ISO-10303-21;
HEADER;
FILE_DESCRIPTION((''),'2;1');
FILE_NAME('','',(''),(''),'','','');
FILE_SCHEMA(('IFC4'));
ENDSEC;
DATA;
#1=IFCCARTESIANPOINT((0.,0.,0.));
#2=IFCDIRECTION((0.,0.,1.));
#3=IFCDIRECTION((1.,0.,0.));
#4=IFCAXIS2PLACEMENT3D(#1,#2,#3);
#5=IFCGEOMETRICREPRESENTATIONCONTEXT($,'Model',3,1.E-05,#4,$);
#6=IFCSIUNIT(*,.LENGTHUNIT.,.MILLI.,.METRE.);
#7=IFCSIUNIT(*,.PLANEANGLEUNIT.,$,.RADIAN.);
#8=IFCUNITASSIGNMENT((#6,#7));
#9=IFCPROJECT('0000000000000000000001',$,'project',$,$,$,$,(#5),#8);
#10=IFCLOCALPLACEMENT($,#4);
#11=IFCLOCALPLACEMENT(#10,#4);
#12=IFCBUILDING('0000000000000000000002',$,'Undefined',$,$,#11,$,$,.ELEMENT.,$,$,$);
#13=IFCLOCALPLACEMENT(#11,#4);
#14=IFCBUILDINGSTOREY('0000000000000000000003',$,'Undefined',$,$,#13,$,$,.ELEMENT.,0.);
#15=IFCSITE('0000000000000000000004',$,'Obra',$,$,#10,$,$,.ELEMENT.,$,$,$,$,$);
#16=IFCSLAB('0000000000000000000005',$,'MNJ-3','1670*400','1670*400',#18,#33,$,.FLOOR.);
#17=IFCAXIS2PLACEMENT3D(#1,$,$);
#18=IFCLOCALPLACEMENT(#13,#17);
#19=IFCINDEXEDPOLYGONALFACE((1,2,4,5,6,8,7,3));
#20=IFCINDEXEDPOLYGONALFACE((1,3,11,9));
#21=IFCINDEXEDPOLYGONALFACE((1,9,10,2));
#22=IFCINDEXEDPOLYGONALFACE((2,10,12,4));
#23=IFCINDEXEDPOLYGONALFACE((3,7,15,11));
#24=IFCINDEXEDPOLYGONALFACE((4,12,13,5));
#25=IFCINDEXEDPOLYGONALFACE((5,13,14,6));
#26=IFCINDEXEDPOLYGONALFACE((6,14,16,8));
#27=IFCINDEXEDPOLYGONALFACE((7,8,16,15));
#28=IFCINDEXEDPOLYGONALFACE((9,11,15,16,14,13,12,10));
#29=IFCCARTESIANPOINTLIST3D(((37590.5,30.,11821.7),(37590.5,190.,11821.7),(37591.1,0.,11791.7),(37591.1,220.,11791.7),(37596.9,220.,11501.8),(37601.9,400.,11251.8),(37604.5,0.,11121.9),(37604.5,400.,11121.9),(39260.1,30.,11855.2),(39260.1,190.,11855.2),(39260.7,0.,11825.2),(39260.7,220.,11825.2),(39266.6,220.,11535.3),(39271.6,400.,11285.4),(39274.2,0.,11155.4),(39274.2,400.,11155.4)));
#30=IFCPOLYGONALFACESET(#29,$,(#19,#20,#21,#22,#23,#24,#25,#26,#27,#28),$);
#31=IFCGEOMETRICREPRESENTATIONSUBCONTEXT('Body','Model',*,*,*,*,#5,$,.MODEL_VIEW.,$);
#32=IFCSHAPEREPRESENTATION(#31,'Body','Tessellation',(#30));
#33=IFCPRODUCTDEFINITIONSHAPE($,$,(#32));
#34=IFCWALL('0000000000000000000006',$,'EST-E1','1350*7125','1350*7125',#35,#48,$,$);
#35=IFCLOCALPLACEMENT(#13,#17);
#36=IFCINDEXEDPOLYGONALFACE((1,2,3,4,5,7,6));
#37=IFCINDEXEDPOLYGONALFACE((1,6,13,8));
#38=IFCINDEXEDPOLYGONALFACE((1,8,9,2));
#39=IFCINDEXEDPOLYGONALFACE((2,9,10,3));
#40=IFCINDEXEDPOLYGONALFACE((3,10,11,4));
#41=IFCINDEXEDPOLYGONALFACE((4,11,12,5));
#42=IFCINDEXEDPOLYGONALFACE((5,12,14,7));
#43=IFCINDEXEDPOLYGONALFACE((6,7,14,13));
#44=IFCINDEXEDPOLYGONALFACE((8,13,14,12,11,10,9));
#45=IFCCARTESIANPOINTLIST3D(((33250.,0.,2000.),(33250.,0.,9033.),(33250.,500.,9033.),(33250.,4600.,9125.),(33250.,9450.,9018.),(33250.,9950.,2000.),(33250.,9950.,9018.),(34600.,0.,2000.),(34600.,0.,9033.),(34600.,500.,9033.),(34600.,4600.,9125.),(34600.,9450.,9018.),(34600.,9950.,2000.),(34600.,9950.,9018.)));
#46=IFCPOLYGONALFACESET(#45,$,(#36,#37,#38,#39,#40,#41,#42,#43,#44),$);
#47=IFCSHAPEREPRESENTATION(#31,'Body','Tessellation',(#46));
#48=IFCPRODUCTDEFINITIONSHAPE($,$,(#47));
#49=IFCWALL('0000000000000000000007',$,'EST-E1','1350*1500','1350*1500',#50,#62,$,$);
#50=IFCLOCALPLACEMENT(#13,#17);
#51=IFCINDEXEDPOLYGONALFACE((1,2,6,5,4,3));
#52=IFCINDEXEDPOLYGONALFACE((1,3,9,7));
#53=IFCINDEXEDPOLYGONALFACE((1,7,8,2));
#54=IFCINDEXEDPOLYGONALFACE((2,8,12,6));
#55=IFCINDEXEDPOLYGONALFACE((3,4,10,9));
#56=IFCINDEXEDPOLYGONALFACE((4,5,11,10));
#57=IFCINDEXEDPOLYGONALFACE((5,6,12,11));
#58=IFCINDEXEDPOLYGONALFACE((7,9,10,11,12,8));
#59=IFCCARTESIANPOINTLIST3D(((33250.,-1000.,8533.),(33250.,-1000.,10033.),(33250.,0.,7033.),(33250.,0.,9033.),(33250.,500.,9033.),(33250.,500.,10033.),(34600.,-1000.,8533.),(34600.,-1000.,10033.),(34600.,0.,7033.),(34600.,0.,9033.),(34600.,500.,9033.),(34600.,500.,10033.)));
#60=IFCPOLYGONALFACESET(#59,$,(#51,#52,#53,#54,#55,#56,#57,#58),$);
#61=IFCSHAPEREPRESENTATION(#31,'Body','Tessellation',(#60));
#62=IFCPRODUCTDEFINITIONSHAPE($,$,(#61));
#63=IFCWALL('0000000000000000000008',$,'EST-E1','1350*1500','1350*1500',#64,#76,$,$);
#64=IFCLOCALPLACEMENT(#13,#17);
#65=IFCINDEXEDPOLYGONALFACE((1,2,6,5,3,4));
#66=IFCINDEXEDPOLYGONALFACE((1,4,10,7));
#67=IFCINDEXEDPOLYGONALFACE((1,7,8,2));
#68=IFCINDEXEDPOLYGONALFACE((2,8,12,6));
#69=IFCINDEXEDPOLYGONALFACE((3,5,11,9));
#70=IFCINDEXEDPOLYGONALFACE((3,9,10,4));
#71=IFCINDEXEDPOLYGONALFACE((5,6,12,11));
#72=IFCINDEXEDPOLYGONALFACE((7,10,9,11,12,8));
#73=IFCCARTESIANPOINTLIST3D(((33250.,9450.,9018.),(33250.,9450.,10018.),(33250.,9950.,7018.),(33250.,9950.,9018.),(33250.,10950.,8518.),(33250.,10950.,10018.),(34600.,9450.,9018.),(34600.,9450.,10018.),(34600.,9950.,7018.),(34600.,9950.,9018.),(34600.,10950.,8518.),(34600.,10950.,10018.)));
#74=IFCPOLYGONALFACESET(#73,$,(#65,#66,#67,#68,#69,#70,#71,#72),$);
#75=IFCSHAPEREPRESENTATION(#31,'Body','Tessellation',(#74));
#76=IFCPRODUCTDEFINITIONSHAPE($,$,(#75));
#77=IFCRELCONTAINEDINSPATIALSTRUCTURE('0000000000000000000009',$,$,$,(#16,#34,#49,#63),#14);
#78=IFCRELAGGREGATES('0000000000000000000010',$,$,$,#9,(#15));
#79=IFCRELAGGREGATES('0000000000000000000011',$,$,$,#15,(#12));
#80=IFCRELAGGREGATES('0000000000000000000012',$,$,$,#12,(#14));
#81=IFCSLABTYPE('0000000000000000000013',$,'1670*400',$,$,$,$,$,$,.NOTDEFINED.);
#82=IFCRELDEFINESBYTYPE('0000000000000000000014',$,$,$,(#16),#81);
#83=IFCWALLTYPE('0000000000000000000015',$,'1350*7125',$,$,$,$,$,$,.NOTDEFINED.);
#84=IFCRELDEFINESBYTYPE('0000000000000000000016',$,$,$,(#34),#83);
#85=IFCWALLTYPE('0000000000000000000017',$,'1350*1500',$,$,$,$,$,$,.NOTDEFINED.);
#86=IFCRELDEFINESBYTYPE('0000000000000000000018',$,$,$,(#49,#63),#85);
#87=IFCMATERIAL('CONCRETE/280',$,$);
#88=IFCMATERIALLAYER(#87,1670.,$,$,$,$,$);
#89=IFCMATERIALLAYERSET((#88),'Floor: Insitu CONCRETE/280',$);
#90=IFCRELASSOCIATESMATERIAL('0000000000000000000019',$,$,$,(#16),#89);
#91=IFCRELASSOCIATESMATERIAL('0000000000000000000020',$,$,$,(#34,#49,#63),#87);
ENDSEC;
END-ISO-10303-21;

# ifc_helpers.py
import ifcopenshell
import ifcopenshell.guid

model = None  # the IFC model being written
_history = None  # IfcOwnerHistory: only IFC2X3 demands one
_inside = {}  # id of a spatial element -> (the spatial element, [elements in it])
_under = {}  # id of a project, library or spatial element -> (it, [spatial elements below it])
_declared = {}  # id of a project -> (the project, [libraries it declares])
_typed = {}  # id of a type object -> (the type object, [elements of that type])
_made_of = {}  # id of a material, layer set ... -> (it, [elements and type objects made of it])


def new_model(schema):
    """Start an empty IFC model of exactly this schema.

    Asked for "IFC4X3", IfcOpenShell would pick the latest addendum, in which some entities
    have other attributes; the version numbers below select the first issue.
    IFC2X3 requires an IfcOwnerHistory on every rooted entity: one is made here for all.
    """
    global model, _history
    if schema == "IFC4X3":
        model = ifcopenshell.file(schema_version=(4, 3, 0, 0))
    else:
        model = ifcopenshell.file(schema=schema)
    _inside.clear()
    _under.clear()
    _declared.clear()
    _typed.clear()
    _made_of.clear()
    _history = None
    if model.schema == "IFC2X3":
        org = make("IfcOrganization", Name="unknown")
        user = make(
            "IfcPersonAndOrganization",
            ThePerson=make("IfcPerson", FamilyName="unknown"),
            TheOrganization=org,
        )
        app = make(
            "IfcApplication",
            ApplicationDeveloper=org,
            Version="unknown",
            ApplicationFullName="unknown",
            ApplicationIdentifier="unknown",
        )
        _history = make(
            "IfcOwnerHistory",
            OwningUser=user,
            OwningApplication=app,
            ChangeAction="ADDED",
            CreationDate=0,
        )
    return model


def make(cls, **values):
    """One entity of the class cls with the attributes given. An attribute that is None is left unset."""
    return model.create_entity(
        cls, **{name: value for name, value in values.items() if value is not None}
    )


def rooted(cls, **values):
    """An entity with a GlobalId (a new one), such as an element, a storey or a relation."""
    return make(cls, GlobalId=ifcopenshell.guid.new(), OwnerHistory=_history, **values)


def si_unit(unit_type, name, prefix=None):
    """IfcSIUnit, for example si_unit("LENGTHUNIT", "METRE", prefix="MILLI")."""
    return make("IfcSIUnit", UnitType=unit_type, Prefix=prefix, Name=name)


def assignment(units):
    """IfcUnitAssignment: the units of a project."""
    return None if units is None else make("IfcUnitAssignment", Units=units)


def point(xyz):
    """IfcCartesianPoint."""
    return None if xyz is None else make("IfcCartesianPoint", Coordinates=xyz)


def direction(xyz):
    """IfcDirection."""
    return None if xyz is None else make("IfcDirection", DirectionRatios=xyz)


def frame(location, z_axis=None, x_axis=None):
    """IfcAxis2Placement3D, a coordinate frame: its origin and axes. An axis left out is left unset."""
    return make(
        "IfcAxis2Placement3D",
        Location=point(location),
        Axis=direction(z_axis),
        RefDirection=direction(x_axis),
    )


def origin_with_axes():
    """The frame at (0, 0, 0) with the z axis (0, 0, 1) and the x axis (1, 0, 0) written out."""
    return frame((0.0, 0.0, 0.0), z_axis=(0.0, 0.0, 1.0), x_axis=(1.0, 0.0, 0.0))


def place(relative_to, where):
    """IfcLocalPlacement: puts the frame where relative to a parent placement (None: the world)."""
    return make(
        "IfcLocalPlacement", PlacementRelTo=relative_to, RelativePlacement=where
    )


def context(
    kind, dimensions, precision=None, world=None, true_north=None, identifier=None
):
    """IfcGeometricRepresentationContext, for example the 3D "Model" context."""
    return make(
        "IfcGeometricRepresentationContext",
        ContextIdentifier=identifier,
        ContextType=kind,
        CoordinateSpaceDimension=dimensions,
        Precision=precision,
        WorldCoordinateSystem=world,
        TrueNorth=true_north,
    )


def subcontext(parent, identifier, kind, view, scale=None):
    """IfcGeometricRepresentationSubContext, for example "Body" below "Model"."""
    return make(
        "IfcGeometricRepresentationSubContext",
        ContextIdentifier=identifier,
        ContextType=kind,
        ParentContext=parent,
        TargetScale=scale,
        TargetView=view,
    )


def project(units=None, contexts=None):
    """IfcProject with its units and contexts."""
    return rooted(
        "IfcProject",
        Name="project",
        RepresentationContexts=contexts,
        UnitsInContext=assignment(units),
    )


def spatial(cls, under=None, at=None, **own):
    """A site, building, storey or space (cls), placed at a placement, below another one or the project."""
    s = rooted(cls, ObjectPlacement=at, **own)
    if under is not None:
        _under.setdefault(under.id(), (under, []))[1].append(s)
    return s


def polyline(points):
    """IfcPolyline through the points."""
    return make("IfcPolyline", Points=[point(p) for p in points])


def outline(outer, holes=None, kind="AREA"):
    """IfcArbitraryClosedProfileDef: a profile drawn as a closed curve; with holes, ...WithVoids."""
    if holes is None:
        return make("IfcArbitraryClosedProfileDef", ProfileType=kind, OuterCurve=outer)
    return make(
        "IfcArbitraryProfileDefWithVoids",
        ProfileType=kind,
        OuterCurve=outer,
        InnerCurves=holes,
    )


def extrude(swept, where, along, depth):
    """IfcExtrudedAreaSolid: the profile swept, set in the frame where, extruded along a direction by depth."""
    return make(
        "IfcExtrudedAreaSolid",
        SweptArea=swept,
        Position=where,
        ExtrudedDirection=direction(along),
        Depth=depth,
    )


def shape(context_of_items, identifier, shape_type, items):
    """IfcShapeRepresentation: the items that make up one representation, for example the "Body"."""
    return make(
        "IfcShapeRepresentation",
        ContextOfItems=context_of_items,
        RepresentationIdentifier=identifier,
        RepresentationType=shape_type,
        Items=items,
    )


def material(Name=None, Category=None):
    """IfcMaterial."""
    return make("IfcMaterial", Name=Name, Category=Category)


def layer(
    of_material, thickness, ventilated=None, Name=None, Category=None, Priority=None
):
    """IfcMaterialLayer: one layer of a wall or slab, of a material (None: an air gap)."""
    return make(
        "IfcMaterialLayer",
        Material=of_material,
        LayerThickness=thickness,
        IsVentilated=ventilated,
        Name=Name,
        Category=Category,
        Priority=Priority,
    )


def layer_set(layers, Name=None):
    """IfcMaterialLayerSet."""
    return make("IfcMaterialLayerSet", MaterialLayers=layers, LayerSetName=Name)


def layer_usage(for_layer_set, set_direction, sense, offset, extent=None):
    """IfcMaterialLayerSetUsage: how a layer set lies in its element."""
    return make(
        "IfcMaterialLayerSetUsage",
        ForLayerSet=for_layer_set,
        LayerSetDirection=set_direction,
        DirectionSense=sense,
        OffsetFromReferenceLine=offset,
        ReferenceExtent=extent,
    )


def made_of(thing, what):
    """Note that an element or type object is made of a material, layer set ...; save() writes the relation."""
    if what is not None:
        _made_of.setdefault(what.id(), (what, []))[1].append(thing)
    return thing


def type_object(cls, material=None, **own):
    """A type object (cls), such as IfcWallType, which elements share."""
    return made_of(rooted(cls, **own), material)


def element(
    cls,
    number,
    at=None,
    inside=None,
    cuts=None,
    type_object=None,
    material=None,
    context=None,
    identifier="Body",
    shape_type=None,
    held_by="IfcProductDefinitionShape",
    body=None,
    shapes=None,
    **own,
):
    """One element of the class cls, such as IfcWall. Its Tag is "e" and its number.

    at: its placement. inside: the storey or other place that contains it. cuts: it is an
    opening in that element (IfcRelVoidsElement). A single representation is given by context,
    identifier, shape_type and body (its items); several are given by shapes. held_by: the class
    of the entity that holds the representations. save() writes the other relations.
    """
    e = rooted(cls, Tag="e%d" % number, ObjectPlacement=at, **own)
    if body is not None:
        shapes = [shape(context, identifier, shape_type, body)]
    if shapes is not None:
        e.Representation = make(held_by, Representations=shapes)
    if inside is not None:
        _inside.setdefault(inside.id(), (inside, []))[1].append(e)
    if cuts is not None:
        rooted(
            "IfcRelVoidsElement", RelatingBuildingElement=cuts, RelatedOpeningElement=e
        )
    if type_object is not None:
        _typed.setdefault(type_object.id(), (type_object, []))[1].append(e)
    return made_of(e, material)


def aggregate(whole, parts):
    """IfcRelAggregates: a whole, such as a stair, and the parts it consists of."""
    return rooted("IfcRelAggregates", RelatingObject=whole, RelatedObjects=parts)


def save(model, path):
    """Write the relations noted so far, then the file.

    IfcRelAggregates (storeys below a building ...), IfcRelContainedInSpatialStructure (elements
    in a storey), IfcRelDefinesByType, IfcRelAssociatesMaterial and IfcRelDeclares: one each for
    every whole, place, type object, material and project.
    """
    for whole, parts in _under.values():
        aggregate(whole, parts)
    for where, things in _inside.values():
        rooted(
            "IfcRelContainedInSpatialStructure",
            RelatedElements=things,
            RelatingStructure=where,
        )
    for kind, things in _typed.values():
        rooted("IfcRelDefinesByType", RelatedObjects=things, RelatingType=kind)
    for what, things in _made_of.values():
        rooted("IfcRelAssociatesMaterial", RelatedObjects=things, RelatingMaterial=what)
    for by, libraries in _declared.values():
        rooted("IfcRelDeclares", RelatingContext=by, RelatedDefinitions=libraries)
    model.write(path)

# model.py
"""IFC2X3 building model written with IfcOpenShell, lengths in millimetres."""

from ifc_helpers import new_model, si_unit, frame, origin_with_axes, place, context, subcontext, project, spatial, polyline, outline, extrude, material, layer, layer_set, layer_usage, type_object, element, save


model = new_model("IFC2X3")

# Units and contexts
model_context = context("Model", 3, precision=1e-05, world=origin_with_axes())
body_context = subcontext(model_context, "Body", "Model", "MODEL_VIEW")
ifc_project = project(units=[si_unit("LENGTHUNIT", "METRE", prefix="MILLI"), si_unit("PLANEANGLEUNIT", "RADIAN")], contexts=[model_context])

# Site, building, storey
site_placement = place(None, origin_with_axes())
site = spatial("IfcSite", under=ifc_project, at=site_placement, Name="Obra", CompositionType="ELEMENT")
building_placement = place(site_placement, origin_with_axes())
building = spatial("IfcBuilding", under=site, at=building_placement, Name="Undefined", CompositionType="ELEMENT")
storey_placement = place(building_placement, origin_with_axes())
storey = spatial("IfcBuildingStorey", under=building, at=storey_placement, Name="Undefined", CompositionType="ELEMENT", Elevation=0.0)

# Shared definitions
ifc_material_1 = material(Name="CONCRETE/280")

# Slab
ifc_layer_1 = layer(ifc_material_1, 1670.0)
ifc_layer_set_1 = layer_set([ifc_layer_1], Name="Floor: Insitu CONCRETE/280")
slab_type_1 = type_object("IfcSlabType", Name="1670*400", PredefinedType="NOTDEFINED")
ifc_layer_usage_1 = layer_usage(ifc_layer_set_1, "AXIS3", "POSITIVE", -835.0)
slab_1_placement = place(storey_placement, frame((38425.9, 0.0, 11808.5), z_axis=(0.999799, 0.0, 0.02007), x_axis=(0.02007, 0.0, -0.999799)))
element("IfcSlab", 1, at=slab_1_placement, inside=storey, type_object=slab_type_1, material=ifc_layer_usage_1, Name="MNJ-3", Description="1670*400", ObjectType="1670*400", PredefinedType="FLOOR", context=body_context, shape_type="SweptSolid", body=[
    extrude(outline(polyline([(0.0, 0.0), (670.0, 0.0), (670.0, 400.0), (540.0, 400.0), (290.0, 220.0), (0.0, 220.0), (-30.0, 190.0), (-30.0, 30.0), (0.0, 0.0)])), frame((0.0, 0.0, -835.0), z_axis=(0.0, 0.0, 1.0), x_axis=(1.0, 0.0, 0.0)), (0.0, 0.0, 1.0), 1670.0),
])

# Walls
wall_type_1 = type_object("IfcWallType", Name="1350*7125", PredefinedType="NOTDEFINED")
wall_placement = place(storey_placement, frame((33925.0, 9450.0, 9018.0), z_axis=(-1.0, 0.0, 0.0), x_axis=(0.0, 1.0, 0.0)))
element("IfcWall", 2, at=wall_placement, inside=storey, type_object=wall_type_1, material=ifc_material_1, Name="EST-E1", Description="1350*7125", ObjectType="1350*7125", context=body_context, shape_type="SweptSolid", body=[
    extrude(outline(polyline([(0.0, 0.0), (500.0, 0.0), (500.0, 7018.0), (-9450.0, 7018.0), (-9450.0, -15.0), (-8950.0, -15.0), (-4850.0, -107.0), (0.0, 0.0)])), frame((0.0, 0.0, -675.0), z_axis=(0.0, 0.0, 1.0), x_axis=(1.0, 0.0, 0.0)), (0.0, 0.0, 1.0), 1350.0),
])
wall_type_2 = type_object("IfcWallType", Name="1350*1500", PredefinedType="NOTDEFINED")
for number, where, z_axis, x_axis, name in (
    (3, (33925.0, -1000.0, 10033.0), (1.0, 0.0, 0.0), (0.0, 0.0, -1.0), "EST-E1"),
    (4, (33925.0, 10950.0, 10018.0), (-1.0, 0.0, 0.0), (0.0, 0.0, -1.0), "EST-E1"),
):
    element("IfcWall", number, at=place(storey_placement, frame(where, z_axis=z_axis, x_axis=x_axis)), inside=storey, type_object=wall_type_2, material=ifc_material_1, Name=name, Description="1350*1500", ObjectType="1350*1500", context=body_context, shape_type="SweptSolid", body=[
        extrude(outline(polyline([(0.0, 0.0), (1500.0, 0.0), (3000.0, 1000.0), (1000.0, 1000.0), (1000.0, 1500.0), (0.0, 1500.0), (0.0, 0.0)])), frame((0.0, 0.0, -675.0), z_axis=(0.0, 0.0, 1.0), x_axis=(1.0, 0.0, 0.0)), (0.0, 0.0, 1.0), 1350.0),
    ])

save(model, "model.ifc")
